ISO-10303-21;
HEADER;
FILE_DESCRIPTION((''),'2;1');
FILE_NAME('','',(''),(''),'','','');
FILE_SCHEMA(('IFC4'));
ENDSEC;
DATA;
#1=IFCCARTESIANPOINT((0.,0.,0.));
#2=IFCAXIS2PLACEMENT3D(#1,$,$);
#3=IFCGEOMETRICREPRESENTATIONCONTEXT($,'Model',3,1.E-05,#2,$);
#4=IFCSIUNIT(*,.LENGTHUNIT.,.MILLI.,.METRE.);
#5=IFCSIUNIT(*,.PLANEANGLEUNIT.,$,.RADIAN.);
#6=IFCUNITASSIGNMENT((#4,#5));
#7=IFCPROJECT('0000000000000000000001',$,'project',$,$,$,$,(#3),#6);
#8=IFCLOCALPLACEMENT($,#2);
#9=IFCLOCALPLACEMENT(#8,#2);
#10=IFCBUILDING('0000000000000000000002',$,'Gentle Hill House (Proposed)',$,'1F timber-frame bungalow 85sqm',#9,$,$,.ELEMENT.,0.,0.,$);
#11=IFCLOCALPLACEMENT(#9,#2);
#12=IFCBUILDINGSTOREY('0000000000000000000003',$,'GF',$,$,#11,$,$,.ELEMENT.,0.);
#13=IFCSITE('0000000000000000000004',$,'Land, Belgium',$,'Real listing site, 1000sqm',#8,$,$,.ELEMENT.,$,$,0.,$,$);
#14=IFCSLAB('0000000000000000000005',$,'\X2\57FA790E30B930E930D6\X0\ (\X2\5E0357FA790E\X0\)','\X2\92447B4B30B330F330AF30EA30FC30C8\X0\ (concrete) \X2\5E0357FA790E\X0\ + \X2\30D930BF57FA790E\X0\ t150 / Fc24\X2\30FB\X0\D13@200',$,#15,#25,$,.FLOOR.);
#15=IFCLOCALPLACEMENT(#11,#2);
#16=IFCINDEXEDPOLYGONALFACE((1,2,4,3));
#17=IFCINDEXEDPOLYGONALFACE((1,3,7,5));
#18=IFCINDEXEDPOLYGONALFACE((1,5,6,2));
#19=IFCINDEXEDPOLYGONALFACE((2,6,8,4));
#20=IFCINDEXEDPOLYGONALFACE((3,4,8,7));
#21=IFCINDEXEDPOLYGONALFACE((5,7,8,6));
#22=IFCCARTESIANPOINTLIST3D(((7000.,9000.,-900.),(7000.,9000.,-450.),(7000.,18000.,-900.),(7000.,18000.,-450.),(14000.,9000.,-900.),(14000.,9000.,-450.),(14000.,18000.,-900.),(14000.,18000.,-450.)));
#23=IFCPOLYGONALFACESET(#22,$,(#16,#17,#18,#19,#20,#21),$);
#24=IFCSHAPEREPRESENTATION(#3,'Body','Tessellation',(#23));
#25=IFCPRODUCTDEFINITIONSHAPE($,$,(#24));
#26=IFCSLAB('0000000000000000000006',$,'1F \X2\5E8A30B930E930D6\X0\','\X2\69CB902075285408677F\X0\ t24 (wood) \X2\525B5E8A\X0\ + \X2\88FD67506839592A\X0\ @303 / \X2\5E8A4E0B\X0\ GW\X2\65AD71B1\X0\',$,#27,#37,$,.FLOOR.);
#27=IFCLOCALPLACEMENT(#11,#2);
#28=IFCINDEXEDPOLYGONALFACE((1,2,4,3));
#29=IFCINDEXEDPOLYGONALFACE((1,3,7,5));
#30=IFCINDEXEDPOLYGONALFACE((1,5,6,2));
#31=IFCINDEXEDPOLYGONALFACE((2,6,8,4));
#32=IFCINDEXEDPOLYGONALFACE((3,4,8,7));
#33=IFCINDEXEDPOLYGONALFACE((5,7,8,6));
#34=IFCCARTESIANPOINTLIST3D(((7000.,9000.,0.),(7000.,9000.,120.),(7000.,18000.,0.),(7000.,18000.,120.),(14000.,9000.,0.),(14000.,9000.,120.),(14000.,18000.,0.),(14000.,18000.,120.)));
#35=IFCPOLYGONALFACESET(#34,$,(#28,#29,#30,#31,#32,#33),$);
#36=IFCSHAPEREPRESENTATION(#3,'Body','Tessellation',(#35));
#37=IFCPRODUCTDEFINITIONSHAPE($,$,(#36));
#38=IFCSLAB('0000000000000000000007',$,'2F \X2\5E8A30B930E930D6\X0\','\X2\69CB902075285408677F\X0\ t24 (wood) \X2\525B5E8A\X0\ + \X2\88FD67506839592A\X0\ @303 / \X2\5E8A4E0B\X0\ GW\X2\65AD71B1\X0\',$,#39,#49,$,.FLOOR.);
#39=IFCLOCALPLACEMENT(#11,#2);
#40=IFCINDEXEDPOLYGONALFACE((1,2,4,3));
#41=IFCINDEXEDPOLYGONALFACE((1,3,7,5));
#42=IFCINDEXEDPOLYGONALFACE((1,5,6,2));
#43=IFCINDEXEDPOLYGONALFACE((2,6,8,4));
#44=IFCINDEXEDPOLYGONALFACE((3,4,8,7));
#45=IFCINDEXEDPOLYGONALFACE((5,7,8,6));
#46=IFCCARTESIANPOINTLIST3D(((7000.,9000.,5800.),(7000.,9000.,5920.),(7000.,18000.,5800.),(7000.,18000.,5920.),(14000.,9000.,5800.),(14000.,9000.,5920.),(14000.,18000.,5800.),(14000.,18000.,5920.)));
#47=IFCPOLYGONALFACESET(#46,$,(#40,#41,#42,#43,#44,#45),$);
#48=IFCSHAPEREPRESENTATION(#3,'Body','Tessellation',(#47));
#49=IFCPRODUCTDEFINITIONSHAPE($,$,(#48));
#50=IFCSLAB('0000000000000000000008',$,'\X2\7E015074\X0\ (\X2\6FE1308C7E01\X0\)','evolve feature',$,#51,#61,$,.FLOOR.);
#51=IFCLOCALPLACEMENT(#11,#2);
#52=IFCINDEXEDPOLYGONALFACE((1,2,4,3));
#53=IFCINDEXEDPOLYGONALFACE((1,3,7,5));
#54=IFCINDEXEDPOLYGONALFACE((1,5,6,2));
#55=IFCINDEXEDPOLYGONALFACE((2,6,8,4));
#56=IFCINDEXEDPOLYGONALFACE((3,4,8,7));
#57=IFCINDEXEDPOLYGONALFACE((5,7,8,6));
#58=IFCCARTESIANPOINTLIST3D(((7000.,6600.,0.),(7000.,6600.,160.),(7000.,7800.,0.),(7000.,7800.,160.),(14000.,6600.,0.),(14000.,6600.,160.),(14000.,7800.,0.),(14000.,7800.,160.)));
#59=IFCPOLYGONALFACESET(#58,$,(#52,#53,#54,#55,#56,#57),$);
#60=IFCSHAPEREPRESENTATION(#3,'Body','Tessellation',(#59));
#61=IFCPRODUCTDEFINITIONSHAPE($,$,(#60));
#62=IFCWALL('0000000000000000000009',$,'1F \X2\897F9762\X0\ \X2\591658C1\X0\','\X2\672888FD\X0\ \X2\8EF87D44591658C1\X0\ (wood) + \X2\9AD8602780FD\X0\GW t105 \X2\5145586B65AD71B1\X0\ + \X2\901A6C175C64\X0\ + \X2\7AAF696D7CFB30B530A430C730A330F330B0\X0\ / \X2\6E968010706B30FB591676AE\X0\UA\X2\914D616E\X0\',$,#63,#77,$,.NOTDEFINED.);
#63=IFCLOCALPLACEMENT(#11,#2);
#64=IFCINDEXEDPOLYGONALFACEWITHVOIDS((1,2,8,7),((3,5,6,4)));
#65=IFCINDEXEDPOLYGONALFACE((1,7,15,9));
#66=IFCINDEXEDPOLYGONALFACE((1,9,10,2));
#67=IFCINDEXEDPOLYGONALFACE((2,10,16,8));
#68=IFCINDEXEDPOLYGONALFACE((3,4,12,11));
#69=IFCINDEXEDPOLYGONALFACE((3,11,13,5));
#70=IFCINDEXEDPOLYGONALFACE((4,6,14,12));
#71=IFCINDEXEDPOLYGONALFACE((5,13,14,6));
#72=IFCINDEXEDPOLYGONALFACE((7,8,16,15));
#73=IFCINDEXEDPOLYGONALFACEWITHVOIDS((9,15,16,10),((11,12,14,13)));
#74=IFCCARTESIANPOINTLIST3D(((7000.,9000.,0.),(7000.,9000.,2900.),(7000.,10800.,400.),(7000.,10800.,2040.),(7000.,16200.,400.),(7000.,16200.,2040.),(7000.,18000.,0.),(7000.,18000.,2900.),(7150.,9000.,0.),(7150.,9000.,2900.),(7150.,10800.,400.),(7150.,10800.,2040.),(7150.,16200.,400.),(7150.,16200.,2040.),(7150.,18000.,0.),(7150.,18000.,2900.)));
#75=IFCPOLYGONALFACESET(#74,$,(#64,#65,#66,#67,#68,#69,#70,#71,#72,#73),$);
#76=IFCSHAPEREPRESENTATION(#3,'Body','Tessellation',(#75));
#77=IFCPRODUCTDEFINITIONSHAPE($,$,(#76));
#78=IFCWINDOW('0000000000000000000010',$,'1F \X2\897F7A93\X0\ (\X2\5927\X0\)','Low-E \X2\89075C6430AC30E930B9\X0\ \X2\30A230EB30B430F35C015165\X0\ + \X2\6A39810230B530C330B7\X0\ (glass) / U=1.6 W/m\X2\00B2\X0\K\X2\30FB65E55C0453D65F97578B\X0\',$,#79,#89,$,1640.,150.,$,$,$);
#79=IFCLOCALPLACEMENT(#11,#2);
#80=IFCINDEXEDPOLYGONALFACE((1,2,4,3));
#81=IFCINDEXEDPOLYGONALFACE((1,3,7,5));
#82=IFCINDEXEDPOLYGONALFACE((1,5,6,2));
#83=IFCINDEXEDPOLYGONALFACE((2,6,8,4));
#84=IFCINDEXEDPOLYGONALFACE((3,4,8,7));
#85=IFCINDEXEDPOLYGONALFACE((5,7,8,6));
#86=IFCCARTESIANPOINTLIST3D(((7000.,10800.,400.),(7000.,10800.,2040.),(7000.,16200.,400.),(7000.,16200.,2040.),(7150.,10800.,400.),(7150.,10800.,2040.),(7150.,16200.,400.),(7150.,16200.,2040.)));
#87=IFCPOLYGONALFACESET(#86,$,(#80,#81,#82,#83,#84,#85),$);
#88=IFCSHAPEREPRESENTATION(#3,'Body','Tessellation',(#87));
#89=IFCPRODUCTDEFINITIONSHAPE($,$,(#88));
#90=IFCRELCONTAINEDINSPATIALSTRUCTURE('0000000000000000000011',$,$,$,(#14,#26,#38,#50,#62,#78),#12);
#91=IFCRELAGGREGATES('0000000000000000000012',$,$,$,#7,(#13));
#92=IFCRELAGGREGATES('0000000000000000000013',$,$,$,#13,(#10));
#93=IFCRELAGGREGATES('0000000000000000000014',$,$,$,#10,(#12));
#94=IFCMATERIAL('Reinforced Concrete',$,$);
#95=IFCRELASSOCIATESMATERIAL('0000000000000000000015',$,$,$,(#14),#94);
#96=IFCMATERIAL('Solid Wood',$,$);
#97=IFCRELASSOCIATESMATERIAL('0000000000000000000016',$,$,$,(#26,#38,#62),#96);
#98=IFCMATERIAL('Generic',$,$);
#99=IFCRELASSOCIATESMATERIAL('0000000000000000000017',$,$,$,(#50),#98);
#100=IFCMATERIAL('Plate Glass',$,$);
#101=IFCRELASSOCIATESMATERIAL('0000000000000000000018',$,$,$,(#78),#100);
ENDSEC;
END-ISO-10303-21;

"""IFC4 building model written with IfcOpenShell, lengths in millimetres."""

from ifc_helpers import new_model, si_unit, frame, frame_2d, origin, place, context, project, spatial, rectangle, extrude, material, element, fill, save


model = new_model("IFC4")

# Units and contexts
model_context = context("Model", 3, precision=1e-05, world=origin())
ifc_project = project(units=[si_unit("LENGTHUNIT", "METRE", prefix="MILLI"), si_unit("PLANEANGLEUNIT", "RADIAN")], contexts=[model_context])

# Site, building, storey
site_placement = place(None, origin())
site = spatial("IfcSite", under=ifc_project, at=site_placement, Name="Land, Belgium", ObjectType="Real listing site, 1000sqm", CompositionType="ELEMENT", RefElevation=0.0)
building_placement = place(site_placement, origin())
building = spatial("IfcBuilding", under=site, at=building_placement, Name="Gentle Hill House (Proposed)", ObjectType="1F timber-frame bungalow 85sqm", CompositionType="ELEMENT", ElevationOfRefHeight=0.0, ElevationOfTerrain=0.0)
storey_placement = place(building_placement, origin())
storey = spatial("IfcBuildingStorey", under=building, at=storey_placement, Name="GF", CompositionType="ELEMENT", Elevation=0.0)

# Slabs
ifc_material_1 = material(Name="Reinforced Concrete")
slab_1_placement = place(storey_placement, frame((3500.0, 4500.0, -450.0)))
element("IfcSlab", 1, at=slab_1_placement, inside=storey, material=ifc_material_1, Name="基礎スラブ (布基礎)", Description="鉄筋コンクリート (concrete) 布基礎 + ベタ基礎 t150 / Fc24・D13@200", PredefinedType="FLOOR", context=model_context, shape_type="SweptSolid", body=[
    extrude(rectangle(XDim=7000.0, YDim=9000.0, at=frame_2d((3500.0, 4500.0))), frame((3500.0, 4500.0, -450.0)), (0.0, 0.0, 1.0), 450.0),
])
ifc_material_2 = material(Name="Solid Wood")
slab_2_placement = place(storey_placement, frame((3500.0, 4500.0, 0.0)))
element("IfcSlab", 2, at=slab_2_placement, inside=storey, material=ifc_material_2, Name="1F 床スラブ", Description="構造用合板 t24 (wood) 剛床 + 製材根太 @303 / 床下 GW断熱", PredefinedType="FLOOR", context=model_context, shape_type="SweptSolid", body=[
    extrude(rectangle(XDim=7000.0, YDim=9000.0, at=frame_2d((3500.0, 4500.0))), frame((3500.0, 4500.0, 0.0)), (0.0, 0.0, 1.0), 120.0),
])
slab_3_placement = place(storey_placement, frame((3500.0, 4500.0, 2900.0)))
element("IfcSlab", 3, at=slab_3_placement, inside=storey, material=ifc_material_2, Name="2F 床スラブ", Description="構造用合板 t24 (wood) 剛床 + 製材根太 @303 / 床下 GW断熱", PredefinedType="FLOOR", context=model_context, shape_type="SweptSolid", body=[
    extrude(rectangle(XDim=7000.0, YDim=9000.0, at=frame_2d((3500.0, 4500.0))), frame((3500.0, 4500.0, 2900.0)), (0.0, 0.0, 1.0), 120.0),
])
ifc_material_3 = material(Name="Generic")
slab_4_placement = place(storey_placement, frame((3500.0, 3300.0, 0.0)))
element("IfcSlab", 4, at=slab_4_placement, inside=storey, material=ifc_material_3, Name="縁側 (濡れ縁)", Description="evolve feature", PredefinedType="FLOOR", context=model_context, shape_type="SweptSolid", body=[
    extrude(rectangle(XDim=7000.0, YDim=1200.0, at=frame_2d((3500.0, 600.0))), frame((3500.0, 3300.0, 0.0)), (0.0, 0.0, 1.0), 160.0),
])

# Shared definitions
ifc_material_4 = material(Name="Plate Glass")

# Wall, opening, window
wall_1_placement = place(storey_placement, frame((3500.0, 4500.0, 0.0)))
wall_1 = element("IfcWall", 5, at=wall_1_placement, inside=storey, material=ifc_material_2, Name="1F 西面 外壁", Description="木製 軸組外壁 (wood) + 高性能GW t105 充填断熱 + 通気層 + 窯業系サイディング / 準耐火・外皮UA配慮", PredefinedType="NOTDEFINED", context=model_context, shape_type="SweptSolid", body=[
    extrude(rectangle(XDim=150.0, YDim=9000.0, at=frame_2d((75.0, 4500.0))), frame((3500.0, 4500.0, 0.0)), (0.0, 0.0, 1.0), 2900.0),
])
opening_1_placement = place(storey_placement, frame((3500.0, 5400.0, 200.0)))
opening_1 = element("IfcOpeningElement", 6, at=opening_1_placement, cuts=wall_1, PredefinedType="NOTDEFINED", context=model_context, shape_type="SweptSolid", body=[
    extrude(rectangle(XDim=150.0, YDim=5400.0, at=frame_2d((75.0, 2700.0))), frame((3500.0, 5400.0, 200.0)), (0.0, 0.0, 1.0), 1640.0),
])
window_1_placement = place(storey_placement, frame((3500.0, 5400.0, 200.0)))
window_1 = element("IfcWindow", 7, at=window_1_placement, inside=storey, material=ifc_material_4, Name="1F 西窓 (大)", Description="Low-E 複層ガラス アルゴン封入 + 樹脂サッシ (glass) / U=1.6 W/m²K・日射取得型", OverallHeight=1640.0, OverallWidth=150.0, context=model_context, shape_type="SweptSolid", body=[
    extrude(rectangle(XDim=150.0, YDim=5400.0, at=frame_2d((75.0, 2700.0))), frame((3500.0, 5400.0, 200.0)), (0.0, 0.0, 1.0), 1640.0),
])
fill(opening_1, window_1)

save(model, "model.ifc")
